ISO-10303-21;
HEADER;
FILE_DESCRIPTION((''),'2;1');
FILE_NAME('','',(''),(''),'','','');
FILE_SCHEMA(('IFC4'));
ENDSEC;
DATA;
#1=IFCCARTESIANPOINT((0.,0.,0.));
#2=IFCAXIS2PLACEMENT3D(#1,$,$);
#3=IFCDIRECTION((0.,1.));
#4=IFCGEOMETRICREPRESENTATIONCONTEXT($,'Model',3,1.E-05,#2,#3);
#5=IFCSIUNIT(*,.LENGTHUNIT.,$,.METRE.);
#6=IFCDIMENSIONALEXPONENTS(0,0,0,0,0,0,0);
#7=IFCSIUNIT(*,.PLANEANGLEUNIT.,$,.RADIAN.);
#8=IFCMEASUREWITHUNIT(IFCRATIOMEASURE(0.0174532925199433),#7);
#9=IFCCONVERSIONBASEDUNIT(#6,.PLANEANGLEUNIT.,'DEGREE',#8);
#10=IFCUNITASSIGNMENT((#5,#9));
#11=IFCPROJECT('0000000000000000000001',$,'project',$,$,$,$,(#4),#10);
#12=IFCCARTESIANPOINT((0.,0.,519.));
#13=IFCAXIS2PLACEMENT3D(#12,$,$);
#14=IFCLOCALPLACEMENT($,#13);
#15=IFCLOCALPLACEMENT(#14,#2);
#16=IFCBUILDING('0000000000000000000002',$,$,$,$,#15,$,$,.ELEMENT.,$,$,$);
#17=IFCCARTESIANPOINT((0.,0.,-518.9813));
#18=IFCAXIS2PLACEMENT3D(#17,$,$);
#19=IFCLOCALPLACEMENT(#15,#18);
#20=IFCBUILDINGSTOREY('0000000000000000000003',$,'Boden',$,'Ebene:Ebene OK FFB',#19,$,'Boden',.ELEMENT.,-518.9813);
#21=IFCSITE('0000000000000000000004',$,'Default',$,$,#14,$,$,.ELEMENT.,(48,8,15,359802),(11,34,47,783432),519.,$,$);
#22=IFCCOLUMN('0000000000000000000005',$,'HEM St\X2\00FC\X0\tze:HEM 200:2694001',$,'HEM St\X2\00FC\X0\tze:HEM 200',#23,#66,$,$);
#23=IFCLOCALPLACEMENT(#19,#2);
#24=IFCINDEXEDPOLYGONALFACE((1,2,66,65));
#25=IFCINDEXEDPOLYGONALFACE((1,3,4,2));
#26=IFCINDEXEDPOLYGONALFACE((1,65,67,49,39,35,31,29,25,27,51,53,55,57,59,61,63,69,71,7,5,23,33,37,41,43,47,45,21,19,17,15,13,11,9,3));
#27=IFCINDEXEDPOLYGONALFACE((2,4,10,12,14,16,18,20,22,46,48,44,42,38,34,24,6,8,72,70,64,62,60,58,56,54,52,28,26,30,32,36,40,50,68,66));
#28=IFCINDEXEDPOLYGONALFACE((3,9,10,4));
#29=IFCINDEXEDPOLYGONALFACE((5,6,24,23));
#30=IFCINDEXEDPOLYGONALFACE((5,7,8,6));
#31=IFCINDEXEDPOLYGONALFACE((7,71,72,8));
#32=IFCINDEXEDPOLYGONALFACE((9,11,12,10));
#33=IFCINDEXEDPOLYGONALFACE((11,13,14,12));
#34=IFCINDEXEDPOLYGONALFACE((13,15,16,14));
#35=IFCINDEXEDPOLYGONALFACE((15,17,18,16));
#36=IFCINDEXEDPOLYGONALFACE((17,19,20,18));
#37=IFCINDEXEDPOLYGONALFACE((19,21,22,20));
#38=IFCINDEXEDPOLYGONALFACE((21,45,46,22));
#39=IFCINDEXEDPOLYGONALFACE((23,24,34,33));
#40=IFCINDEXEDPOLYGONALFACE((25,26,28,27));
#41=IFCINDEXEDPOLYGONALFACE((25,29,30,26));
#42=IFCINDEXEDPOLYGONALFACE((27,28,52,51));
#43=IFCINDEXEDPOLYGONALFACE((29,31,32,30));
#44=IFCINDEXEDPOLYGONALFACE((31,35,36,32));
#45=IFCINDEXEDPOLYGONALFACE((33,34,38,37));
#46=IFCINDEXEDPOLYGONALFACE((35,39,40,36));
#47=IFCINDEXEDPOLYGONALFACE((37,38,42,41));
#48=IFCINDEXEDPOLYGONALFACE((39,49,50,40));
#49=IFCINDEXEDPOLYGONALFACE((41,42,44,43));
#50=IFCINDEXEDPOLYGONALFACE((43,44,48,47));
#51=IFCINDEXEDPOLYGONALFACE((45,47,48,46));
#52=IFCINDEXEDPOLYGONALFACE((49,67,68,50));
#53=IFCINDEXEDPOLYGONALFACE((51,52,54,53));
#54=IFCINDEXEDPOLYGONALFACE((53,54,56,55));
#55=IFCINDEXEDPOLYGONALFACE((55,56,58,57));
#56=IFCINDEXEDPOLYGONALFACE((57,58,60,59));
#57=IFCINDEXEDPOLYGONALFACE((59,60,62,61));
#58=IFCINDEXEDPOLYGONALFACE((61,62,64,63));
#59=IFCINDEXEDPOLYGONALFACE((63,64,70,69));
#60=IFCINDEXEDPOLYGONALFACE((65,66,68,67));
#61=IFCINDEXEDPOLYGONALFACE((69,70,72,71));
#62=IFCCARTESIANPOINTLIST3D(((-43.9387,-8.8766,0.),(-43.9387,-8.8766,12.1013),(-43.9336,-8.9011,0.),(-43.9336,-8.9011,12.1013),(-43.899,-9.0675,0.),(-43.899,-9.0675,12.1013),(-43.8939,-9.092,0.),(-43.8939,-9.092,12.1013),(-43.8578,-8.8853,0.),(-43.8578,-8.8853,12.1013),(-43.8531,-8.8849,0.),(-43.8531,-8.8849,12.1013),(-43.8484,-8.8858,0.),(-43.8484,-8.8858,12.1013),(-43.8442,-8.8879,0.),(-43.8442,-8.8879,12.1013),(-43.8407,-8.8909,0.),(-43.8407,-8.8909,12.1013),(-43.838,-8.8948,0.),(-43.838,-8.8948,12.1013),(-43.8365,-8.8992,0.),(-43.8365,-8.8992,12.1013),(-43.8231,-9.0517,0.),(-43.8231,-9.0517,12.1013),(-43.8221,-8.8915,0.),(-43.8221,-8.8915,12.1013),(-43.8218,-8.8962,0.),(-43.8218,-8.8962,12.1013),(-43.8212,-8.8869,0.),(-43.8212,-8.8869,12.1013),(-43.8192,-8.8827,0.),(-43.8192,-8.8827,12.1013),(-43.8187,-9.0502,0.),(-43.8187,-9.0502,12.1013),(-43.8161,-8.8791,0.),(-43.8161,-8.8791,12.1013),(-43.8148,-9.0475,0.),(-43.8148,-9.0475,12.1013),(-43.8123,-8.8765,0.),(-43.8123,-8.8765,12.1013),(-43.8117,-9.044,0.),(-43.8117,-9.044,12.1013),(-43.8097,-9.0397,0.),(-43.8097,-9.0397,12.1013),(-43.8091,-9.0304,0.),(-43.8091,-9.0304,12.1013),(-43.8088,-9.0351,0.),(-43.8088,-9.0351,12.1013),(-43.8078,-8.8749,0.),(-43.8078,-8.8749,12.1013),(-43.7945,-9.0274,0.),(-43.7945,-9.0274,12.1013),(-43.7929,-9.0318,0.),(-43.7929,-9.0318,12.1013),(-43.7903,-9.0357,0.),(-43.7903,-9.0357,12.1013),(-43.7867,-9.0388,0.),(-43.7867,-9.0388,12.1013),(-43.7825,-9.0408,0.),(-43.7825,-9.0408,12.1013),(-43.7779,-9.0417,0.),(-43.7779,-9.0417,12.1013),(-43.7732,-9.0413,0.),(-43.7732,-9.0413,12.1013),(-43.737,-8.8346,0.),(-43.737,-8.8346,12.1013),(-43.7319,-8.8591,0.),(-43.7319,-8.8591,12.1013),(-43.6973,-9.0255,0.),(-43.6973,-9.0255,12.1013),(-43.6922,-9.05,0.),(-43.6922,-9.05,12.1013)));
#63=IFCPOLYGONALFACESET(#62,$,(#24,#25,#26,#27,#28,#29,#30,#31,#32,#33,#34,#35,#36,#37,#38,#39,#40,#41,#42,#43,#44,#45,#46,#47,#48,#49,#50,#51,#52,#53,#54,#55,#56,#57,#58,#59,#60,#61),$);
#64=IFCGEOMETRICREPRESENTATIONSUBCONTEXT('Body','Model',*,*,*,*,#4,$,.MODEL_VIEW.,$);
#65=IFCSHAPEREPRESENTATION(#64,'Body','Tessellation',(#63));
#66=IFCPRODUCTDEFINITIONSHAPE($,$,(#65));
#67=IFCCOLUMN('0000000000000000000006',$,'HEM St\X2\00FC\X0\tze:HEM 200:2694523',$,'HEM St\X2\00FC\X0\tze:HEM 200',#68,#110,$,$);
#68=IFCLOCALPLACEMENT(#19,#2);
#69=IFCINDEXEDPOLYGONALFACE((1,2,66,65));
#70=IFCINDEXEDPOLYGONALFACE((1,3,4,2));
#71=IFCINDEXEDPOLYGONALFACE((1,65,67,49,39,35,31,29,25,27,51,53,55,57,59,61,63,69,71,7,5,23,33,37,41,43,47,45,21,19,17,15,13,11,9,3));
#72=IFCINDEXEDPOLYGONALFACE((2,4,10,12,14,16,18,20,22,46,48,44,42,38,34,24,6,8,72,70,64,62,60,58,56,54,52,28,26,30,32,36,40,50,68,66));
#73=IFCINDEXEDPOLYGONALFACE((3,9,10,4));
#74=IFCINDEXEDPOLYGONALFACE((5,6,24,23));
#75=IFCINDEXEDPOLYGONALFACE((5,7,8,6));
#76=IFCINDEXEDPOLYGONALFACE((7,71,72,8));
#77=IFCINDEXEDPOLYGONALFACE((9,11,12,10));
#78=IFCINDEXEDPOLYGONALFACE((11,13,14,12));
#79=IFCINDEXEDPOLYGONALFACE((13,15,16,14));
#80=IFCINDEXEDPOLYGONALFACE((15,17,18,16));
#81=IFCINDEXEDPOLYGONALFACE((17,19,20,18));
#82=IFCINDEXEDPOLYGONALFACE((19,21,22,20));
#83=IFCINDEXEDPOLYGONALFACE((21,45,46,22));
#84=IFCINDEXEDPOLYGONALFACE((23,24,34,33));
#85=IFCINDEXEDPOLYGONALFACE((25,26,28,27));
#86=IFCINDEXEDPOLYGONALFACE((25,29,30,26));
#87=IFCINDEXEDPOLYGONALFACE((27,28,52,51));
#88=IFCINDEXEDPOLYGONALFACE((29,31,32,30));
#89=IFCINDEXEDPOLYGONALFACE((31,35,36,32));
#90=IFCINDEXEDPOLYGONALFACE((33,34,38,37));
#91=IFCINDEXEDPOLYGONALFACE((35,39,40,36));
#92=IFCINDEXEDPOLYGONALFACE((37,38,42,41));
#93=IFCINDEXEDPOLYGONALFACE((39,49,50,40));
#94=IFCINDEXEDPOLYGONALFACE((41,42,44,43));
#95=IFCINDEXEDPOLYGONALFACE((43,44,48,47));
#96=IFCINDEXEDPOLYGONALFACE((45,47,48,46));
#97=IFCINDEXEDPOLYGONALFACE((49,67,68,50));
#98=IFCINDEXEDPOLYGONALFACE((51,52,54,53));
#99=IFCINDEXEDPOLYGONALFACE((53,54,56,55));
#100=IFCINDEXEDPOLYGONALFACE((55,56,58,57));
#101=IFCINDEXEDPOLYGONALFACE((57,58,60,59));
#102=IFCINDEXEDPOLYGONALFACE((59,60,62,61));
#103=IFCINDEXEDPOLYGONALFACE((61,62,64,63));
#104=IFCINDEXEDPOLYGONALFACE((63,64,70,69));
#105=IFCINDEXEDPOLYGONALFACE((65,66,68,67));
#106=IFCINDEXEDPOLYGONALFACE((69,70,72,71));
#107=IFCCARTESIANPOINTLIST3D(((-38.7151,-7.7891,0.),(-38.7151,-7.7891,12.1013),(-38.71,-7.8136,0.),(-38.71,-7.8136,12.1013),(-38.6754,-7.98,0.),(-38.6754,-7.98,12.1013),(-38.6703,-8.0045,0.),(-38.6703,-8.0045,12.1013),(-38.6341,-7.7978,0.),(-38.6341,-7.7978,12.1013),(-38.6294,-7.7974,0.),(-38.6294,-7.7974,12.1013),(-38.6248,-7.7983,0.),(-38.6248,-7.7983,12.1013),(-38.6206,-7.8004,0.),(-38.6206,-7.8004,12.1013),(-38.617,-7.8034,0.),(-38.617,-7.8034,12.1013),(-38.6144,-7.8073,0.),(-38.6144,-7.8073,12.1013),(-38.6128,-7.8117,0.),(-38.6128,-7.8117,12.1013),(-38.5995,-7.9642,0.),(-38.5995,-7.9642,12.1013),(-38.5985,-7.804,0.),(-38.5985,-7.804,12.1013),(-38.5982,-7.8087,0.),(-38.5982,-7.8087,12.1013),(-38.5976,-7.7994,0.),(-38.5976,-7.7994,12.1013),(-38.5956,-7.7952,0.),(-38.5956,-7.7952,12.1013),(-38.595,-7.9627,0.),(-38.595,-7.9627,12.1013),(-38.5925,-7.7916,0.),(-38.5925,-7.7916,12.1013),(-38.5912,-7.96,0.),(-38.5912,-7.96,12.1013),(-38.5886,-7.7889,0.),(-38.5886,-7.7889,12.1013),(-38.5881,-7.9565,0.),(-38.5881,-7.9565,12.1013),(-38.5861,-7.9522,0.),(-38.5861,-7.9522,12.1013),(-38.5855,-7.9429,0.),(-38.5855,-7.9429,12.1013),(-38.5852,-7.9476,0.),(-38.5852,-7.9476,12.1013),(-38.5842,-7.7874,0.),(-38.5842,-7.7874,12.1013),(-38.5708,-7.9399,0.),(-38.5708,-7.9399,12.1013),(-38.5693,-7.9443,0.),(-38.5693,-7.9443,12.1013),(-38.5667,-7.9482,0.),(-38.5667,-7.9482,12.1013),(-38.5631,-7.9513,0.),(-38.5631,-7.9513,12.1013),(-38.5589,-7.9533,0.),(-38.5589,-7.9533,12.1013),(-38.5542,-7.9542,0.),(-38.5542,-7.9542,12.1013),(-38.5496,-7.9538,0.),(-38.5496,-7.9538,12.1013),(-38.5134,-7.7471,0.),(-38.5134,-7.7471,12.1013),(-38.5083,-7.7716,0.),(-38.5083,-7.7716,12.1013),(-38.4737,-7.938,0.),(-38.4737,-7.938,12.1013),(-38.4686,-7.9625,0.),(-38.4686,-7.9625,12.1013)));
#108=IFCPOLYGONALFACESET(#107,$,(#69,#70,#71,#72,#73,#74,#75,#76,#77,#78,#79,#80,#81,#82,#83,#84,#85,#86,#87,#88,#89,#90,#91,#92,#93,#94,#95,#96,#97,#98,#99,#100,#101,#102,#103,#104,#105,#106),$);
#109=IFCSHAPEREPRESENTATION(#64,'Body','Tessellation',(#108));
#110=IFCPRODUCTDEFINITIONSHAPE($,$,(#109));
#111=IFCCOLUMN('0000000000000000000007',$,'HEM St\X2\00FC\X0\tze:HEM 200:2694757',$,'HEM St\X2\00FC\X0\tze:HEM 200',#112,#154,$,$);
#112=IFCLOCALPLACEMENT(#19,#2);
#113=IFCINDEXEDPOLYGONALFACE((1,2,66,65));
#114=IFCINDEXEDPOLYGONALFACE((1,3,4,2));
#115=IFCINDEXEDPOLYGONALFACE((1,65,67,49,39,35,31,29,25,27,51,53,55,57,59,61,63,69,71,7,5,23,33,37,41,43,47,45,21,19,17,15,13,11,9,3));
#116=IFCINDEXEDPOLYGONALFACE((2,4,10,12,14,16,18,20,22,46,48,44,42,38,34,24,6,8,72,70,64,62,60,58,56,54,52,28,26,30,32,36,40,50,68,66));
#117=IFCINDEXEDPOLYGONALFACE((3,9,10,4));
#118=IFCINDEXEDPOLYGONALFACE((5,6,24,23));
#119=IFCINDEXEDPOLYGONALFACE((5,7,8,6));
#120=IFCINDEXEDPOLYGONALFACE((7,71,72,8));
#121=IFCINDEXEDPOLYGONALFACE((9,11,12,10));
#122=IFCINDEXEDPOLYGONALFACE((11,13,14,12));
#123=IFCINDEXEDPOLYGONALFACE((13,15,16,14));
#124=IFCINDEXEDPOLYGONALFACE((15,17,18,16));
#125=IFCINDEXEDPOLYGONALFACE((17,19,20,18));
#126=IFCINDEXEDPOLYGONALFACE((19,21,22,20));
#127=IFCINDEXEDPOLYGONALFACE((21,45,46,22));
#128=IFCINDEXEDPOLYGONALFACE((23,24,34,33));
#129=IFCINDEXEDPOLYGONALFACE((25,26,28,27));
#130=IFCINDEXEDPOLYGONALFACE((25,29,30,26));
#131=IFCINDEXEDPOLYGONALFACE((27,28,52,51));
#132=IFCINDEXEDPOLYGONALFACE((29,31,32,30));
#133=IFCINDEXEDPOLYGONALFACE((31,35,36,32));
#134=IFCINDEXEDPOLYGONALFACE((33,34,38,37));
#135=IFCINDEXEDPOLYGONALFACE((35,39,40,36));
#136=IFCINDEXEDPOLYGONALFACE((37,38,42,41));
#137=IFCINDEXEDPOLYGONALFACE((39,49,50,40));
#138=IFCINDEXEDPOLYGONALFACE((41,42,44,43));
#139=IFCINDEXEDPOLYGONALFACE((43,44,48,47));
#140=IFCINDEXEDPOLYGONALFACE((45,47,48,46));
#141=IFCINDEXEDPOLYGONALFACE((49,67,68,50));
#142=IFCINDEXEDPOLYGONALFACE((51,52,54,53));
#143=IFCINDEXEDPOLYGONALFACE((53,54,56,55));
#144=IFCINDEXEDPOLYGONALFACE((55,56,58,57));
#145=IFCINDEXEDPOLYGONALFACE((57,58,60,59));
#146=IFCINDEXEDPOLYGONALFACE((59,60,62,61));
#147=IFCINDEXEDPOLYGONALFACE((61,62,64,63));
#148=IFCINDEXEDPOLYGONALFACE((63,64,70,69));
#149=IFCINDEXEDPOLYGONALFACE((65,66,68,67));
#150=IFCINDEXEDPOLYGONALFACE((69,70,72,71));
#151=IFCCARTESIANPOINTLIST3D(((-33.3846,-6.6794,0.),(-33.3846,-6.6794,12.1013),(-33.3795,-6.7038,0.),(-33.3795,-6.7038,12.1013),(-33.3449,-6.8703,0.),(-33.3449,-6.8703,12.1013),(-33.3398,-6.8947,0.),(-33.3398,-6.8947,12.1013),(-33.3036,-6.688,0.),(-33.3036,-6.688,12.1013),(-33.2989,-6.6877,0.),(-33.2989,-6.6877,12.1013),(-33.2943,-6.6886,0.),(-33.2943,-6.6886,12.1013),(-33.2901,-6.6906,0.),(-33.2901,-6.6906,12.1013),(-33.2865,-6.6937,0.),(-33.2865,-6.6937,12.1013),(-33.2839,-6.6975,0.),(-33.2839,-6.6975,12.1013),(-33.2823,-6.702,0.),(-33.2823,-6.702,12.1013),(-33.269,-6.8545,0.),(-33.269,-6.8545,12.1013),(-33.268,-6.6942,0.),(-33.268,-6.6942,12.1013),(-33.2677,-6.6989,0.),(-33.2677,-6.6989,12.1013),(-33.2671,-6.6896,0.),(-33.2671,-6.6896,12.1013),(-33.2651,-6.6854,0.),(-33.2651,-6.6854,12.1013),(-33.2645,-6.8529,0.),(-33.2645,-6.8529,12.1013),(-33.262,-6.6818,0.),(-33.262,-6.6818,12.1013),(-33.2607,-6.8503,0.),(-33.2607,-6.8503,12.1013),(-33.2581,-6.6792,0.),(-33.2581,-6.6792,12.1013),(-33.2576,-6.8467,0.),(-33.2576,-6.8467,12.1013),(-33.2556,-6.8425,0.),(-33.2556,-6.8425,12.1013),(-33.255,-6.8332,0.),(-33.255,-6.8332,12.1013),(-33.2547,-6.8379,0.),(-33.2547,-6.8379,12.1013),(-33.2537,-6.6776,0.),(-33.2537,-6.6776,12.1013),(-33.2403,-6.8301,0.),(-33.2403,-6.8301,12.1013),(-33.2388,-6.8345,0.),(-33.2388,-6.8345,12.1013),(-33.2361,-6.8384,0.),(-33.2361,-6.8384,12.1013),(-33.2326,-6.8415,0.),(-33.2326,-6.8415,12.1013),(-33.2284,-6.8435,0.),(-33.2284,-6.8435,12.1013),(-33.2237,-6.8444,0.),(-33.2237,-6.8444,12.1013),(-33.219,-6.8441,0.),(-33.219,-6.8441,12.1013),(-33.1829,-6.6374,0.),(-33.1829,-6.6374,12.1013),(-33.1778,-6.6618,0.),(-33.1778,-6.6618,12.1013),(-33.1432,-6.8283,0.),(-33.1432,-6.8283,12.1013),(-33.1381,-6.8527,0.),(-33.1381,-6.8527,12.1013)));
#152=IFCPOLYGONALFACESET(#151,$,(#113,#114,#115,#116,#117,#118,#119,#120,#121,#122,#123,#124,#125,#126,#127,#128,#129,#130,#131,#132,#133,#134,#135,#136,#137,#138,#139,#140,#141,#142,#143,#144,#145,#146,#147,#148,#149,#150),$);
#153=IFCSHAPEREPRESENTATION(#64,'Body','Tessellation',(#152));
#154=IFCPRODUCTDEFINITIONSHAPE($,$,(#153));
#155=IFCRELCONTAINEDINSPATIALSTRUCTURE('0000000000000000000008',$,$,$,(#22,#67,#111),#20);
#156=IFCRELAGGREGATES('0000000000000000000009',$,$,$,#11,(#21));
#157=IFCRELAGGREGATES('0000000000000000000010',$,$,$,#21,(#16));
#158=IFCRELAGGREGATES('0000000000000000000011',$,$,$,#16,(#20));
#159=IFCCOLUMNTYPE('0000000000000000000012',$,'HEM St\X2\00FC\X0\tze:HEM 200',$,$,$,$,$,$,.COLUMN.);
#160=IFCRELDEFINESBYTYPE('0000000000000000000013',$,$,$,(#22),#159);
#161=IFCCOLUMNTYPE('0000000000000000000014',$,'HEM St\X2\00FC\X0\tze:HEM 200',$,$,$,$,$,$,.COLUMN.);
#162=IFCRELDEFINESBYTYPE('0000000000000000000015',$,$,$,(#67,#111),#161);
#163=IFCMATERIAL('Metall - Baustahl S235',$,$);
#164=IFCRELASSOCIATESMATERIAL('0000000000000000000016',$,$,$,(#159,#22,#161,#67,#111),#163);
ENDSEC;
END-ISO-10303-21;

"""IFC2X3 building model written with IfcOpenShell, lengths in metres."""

from ifc_helpers import new_model, entity, si_unit, converted_unit, direction, frame, frame_2d, origin, place, context, subcontext, project, spatial, polyline, circle_curve, parameter, trimmed, segment, composite_curve, outline, extrude, source, transform, mapped, material, type_object, type_shapes, element, save


model = new_model("IFC2X3")

# Units and contexts
model_context = context("Model", 3, precision=1e-05, world=origin(), true_north=direction((0.0, 1.0)))
body_context = subcontext(model_context, "Body", "Model", "MODEL_VIEW")
ifc_project = project(units=[si_unit("LENGTHUNIT", "METRE"), converted_unit("PLANEANGLEUNIT", "DEGREE", entity("IfcRatioMeasure", 0.0174532925199433), si_unit("PLANEANGLEUNIT", "RADIAN"), dimensions=[0, 0, 0, 0, 0, 0, 0])], contexts=[model_context])

# Site, building, storey
site_placement = place(None, frame((0.0, 0.0, 519.0)))
site = spatial("IfcSite", under=ifc_project, at=site_placement, Name="Default", CompositionType="ELEMENT", RefLatitude=(48, 8, 15, 359802), RefLongitude=(11, 34, 47, 783432), RefElevation=519.0)
building_placement = place(site_placement, origin())
building = spatial("IfcBuilding", under=site, at=building_placement, CompositionType="ELEMENT")
storey_placement = place(building_placement, frame((0.0, 0.0, -518.9813)))
storey = spatial("IfcBuildingStorey", under=building, at=storey_placement, Name="Boden", ObjectType="Ebene:Ebene OK FFB", LongName="Boden", CompositionType="ELEMENT", Elevation=-518.9813)

# Columns
ifc_material_1 = material(Name="Metall - Baustahl S235")
column_type_1 = type_object("IfcColumnType", Name="HEM Stütze:HEM 200", PredefinedType="COLUMN", material=ifc_material_1)
shared_shape_1 = source(origin(), body_context, "Body", "SweptSolid", [
    extrude(outline(composite_curve([segment(polyline([(0.085, -0.103), (0.11, -0.103)]), True, "CONTINUOUS"), segment(polyline([(0.11, -0.103), (0.11, 0.103)]), True, "CONTINUOUS"), segment(polyline([(0.11, 0.103), (0.085, 0.103)]), True, "CONTINUOUS"), segment(polyline([(0.085, 0.103), (0.085, 0.0255)]), True, "CONTINUOUS"), segment(trimmed(circle_curve(frame_2d((0.067, 0.0255), x_axis=(1.0, 0.0)), 0.018), [parameter(270.0)], [parameter(0.0)], True, "PARAMETER"), False, "CONTINUOUS"), segment(polyline([(0.067, 0.0075), (-0.067, 0.0075)]), True, "CONTINUOUS"), segment(trimmed(circle_curve(frame_2d((-0.067, 0.0255), x_axis=(0.0, -1.0)), 0.018), [parameter(270.0)], [parameter(0.0)], True, "PARAMETER"), False, "CONTINUOUS"), segment(polyline([(-0.085, 0.0255), (-0.085, 0.103)]), True, "CONTINUOUS"), segment(polyline([(-0.085, 0.103), (-0.11, 0.103)]), True, "CONTINUOUS"), segment(polyline([(-0.11, 0.103), (-0.11, -0.103)]), True, "CONTINUOUS"), segment(polyline([(-0.11, -0.103), (-0.085, -0.103)]), True, "CONTINUOUS"), segment(polyline([(-0.085, -0.103), (-0.085, -0.0255)]), True, "CONTINUOUS"), segment(trimmed(circle_curve(frame_2d((-0.067, -0.0255), x_axis=(-1.0, 0.0)), 0.018), [parameter(270.0)], [parameter(0.0)], True, "PARAMETER"), False, "CONTINUOUS"), segment(polyline([(-0.067, -0.0075), (0.067, -0.0075)]), True, "CONTINUOUS"), segment(trimmed(circle_curve(frame_2d((0.067, -0.0255), x_axis=(0.0, 1.0)), 0.018), [parameter(270.0)], [parameter(0.0)], True, "PARAMETER"), False, "CONTINUOUS"), segment(polyline([(0.085, -0.0255), (0.085, -0.103)]), True, "CONTINUOUS")], self_intersect=False)), frame((-43.8155, -8.9633, -518.9813), z_axis=(0.0, 0.0, 1.0), x_axis=(-0.20382, 0.979008, 0.0)), (0.0, 0.0, 1.0), 12.1013),
])
type_shapes(column_type_1, [shared_shape_1])
column_1_placement = place(storey_placement, frame((0.0, 0.0, 518.9813)))
element("IfcColumn", 1, at=column_1_placement, inside=storey, type_object=column_type_1, material=ifc_material_1, Name="HEM Stütze:HEM 200:2694001", ObjectType="HEM Stütze:HEM 200", context=body_context, shape_type="MappedRepresentation", body=[
    mapped(shared_shape_1, transform((0.0, 0.0, 0.0), scale=1.0)),
])
column_type_2 = type_object("IfcColumnType", Name="HEM Stütze:HEM 200", PredefinedType="COLUMN", material=ifc_material_1)
shared_shape_2 = source(origin(), body_context, "Body", "SweptSolid", [
    extrude(outline(composite_curve([segment(polyline([(0.085, -0.103), (0.11, -0.103)]), True, "CONTINUOUS"), segment(polyline([(0.11, -0.103), (0.11, 0.103)]), True, "CONTINUOUS"), segment(polyline([(0.11, 0.103), (0.085, 0.103)]), True, "CONTINUOUS"), segment(polyline([(0.085, 0.103), (0.085, 0.0255)]), True, "CONTINUOUS"), segment(trimmed(circle_curve(frame_2d((0.067, 0.0255), x_axis=(1.0, 0.0)), 0.018), [parameter(270.0)], [parameter(0.0)], True, "PARAMETER"), False, "CONTINUOUS"), segment(polyline([(0.067, 0.0075), (-0.067, 0.0075)]), True, "CONTINUOUS"), segment(trimmed(circle_curve(frame_2d((-0.067, 0.0255), x_axis=(0.0, -1.0)), 0.018), [parameter(270.0)], [parameter(0.0)], True, "PARAMETER"), False, "CONTINUOUS"), segment(polyline([(-0.085, 0.0255), (-0.085, 0.103)]), True, "CONTINUOUS"), segment(polyline([(-0.085, 0.103), (-0.11, 0.103)]), True, "CONTINUOUS"), segment(polyline([(-0.11, 0.103), (-0.11, -0.103)]), True, "CONTINUOUS"), segment(polyline([(-0.11, -0.103), (-0.085, -0.103)]), True, "CONTINUOUS"), segment(polyline([(-0.085, -0.103), (-0.085, -0.0255)]), True, "CONTINUOUS"), segment(trimmed(circle_curve(frame_2d((-0.067, -0.0255), x_axis=(-1.0, 0.0)), 0.018), [parameter(270.0)], [parameter(0.0)], True, "PARAMETER"), False, "CONTINUOUS"), segment(polyline([(-0.067, -0.0075), (0.067, -0.0075)]), True, "CONTINUOUS"), segment(trimmed(circle_curve(frame_2d((0.067, -0.0255), x_axis=(0.0, 1.0)), 0.018), [parameter(270.0)], [parameter(0.0)], True, "PARAMETER"), False, "CONTINUOUS"), segment(polyline([(0.085, -0.0255), (0.085, -0.103)]), True, "CONTINUOUS")], self_intersect=False)), frame((0.0, 0.0, -518.9813), z_axis=(0.0, 0.0, 1.0), x_axis=(0.0, -1.0, 0.0)), (0.0, 0.0, 1.0), 12.1013),
])
type_shapes(column_type_2, [shared_shape_2])
for number, where, z_axis, x_axis, name in (
    (2, (-38.5918, -7.8758, 518.9813), (0.0, 0.0, 1.0), (0.979008, 0.20382, 0.0), "HEM Stütze:HEM 200:2694523"),
    (3, (-33.2613, -6.766, 518.9813), (0.0, 0.0, 1.0), (0.979008, 0.20382, 0.0), "HEM Stütze:HEM 200:2694757"),
):
    element("IfcColumn", number, at=place(storey_placement, frame(where, z_axis=z_axis, x_axis=x_axis)), inside=storey, type_object=column_type_2, material=ifc_material_1, Name=name, ObjectType="HEM Stütze:HEM 200", context=body_context, shape_type="MappedRepresentation", body=[
        mapped(shared_shape_2, transform((0.0, 0.0, 0.0), scale=1.0)),
    ])

save(model, "model.ifc")
